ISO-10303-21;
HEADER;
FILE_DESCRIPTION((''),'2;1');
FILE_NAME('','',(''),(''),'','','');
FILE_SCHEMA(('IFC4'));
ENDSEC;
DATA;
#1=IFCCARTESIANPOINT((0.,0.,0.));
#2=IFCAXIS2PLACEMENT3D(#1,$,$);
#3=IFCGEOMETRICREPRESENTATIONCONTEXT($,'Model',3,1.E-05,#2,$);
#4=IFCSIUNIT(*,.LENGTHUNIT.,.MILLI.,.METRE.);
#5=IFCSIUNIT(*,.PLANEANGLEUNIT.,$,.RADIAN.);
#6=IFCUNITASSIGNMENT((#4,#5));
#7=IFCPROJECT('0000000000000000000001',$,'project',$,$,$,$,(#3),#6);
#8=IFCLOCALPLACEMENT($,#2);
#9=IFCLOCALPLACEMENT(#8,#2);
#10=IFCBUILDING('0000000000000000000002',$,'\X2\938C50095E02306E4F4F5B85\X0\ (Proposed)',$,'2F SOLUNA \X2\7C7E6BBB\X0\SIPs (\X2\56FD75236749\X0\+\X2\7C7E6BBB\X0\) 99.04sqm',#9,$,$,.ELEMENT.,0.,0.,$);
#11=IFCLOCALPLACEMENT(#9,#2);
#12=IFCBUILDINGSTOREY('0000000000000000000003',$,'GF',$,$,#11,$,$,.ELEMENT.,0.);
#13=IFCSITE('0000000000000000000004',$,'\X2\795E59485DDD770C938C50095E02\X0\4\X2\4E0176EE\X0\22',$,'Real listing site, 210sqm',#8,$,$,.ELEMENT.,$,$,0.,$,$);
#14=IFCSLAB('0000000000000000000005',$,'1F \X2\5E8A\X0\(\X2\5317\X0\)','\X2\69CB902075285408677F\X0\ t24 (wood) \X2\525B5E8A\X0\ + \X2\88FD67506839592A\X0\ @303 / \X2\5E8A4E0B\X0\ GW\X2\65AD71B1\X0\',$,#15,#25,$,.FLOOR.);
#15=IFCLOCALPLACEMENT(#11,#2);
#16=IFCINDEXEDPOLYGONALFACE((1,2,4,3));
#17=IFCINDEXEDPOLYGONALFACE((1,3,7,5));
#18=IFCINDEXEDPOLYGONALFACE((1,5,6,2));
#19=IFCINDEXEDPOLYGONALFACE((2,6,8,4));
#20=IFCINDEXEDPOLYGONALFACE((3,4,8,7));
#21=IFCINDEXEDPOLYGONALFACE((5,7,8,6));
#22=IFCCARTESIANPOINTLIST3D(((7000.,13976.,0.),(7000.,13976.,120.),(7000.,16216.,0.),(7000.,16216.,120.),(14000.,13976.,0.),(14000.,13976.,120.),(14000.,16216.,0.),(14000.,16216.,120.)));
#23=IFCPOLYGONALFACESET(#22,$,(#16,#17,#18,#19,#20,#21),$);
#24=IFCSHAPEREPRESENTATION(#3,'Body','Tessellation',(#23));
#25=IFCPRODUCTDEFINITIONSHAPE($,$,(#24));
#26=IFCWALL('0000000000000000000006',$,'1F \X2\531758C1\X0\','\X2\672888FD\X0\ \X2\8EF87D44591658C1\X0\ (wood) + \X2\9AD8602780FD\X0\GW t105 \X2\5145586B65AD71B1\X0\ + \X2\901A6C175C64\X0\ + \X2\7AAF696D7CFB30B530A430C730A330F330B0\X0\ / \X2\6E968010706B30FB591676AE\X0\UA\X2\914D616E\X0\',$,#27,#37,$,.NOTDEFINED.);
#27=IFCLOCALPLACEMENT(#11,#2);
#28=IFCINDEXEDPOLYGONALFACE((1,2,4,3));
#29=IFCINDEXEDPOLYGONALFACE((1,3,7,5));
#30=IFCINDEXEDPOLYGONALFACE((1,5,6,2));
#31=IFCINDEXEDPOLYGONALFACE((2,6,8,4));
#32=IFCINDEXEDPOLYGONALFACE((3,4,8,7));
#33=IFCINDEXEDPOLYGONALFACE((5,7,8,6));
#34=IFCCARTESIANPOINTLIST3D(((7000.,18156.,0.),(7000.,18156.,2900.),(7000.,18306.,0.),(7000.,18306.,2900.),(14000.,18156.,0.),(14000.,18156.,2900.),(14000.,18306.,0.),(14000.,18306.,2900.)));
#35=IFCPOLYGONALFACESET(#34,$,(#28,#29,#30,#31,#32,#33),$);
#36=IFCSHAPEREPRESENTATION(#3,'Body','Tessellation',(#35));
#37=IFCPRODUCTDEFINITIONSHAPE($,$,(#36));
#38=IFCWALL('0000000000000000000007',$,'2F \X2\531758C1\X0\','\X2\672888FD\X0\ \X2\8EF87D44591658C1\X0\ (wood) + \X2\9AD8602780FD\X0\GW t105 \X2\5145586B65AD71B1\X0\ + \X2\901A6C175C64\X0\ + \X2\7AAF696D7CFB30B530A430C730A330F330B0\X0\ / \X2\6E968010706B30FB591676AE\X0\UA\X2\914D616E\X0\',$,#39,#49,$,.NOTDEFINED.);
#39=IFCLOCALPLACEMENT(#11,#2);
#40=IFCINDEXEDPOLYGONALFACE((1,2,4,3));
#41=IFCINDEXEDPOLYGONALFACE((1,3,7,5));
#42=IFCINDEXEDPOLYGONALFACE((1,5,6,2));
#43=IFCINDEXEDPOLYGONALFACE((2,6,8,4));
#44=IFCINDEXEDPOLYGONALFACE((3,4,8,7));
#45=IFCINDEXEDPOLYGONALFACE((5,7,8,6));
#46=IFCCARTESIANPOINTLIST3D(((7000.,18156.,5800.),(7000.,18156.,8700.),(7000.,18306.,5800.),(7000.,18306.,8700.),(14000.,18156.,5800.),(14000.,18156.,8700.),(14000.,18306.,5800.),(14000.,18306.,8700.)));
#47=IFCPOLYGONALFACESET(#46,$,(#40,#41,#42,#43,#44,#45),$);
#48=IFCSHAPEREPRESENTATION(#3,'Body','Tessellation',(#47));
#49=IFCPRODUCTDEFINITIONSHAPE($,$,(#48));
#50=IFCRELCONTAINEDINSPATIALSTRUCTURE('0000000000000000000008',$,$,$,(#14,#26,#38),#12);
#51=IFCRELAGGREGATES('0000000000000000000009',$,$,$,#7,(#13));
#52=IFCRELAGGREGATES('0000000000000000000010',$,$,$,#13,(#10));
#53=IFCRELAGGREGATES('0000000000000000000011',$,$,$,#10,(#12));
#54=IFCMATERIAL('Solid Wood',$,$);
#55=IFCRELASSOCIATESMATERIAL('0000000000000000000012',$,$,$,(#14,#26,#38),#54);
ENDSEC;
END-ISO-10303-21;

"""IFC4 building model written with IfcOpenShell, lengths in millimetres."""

from ifc_helpers import new_model, si_unit, frame, frame_2d, origin, place, context, project, spatial, rectangle, extrude, material, element, save


model = new_model("IFC4")

# Units and contexts
model_context = context("Model", 3, precision=1e-05, world=origin())
ifc_project = project(units=[si_unit("LENGTHUNIT", "METRE", prefix="MILLI"), si_unit("PLANEANGLEUNIT", "RADIAN")], contexts=[model_context])

# Site, building, storey
site_placement = place(None, origin())
site = spatial("IfcSite", under=ifc_project, at=site_placement, Name="神奈川県鎌倉市4丁目22", ObjectType="Real listing site, 210sqm", CompositionType="ELEMENT", RefElevation=0.0)
building_placement = place(site_placement, origin())
building = spatial("IfcBuilding", under=site, at=building_placement, Name="鎌倉市の住宅 (Proposed)", ObjectType="2F SOLUNA 籾殻SIPs (国産杉+籾殻) 99.04sqm", CompositionType="ELEMENT", ElevationOfRefHeight=0.0, ElevationOfTerrain=0.0)
storey_placement = place(building_placement, origin())
storey = spatial("IfcBuildingStorey", under=building, at=storey_placement, Name="GF", CompositionType="ELEMENT", Elevation=0.0)

# Slab
ifc_material_1 = material(Name="Solid Wood")
slab_1_placement = place(storey_placement, frame((3500.0, 6988.0, 0.0)))
element("IfcSlab", 1, at=slab_1_placement, inside=storey, material=ifc_material_1, Name="1F 床(北)", Description="構造用合板 t24 (wood) 剛床 + 製材根太 @303 / 床下 GW断熱", PredefinedType="FLOOR", context=model_context, shape_type="SweptSolid", body=[
    extrude(rectangle(XDim=7000.0, YDim=2240.0, at=frame_2d((3500.0, 1120.0))), frame((3500.0, 6988.0, 0.0)), (0.0, 0.0, 1.0), 120.0),
])

# Wall
wall_1_placement = place(storey_placement, frame((3500.0, 9078.0, 0.0)))
element("IfcWall", 2, at=wall_1_placement, inside=storey, material=ifc_material_1, Name="1F 北壁", Description="木製 軸組外壁 (wood) + 高性能GW t105 充填断熱 + 通気層 + 窯業系サイディング / 準耐火・外皮UA配慮", PredefinedType="NOTDEFINED", context=model_context, shape_type="SweptSolid", body=[
    extrude(rectangle(XDim=7000.0, YDim=150.0, at=frame_2d((3500.0, 75.0))), frame((3500.0, 9078.0, 0.0)), (0.0, 0.0, 1.0), 2900.0),
])

# Wall
wall_2_placement = place(storey_placement, frame((3500.0, 9078.0, 2900.0)))
element("IfcWall", 3, at=wall_2_placement, inside=storey, material=ifc_material_1, Name="2F 北壁", Description="木製 軸組外壁 (wood) + 高性能GW t105 充填断熱 + 通気層 + 窯業系サイディング / 準耐火・外皮UA配慮", PredefinedType="NOTDEFINED", context=model_context, shape_type="SweptSolid", body=[
    extrude(rectangle(XDim=7000.0, YDim=150.0, at=frame_2d((3500.0, 75.0))), frame((3500.0, 9078.0, 2900.0)), (0.0, 0.0, 1.0), 2900.0),
])

save(model, "model.ifc")
